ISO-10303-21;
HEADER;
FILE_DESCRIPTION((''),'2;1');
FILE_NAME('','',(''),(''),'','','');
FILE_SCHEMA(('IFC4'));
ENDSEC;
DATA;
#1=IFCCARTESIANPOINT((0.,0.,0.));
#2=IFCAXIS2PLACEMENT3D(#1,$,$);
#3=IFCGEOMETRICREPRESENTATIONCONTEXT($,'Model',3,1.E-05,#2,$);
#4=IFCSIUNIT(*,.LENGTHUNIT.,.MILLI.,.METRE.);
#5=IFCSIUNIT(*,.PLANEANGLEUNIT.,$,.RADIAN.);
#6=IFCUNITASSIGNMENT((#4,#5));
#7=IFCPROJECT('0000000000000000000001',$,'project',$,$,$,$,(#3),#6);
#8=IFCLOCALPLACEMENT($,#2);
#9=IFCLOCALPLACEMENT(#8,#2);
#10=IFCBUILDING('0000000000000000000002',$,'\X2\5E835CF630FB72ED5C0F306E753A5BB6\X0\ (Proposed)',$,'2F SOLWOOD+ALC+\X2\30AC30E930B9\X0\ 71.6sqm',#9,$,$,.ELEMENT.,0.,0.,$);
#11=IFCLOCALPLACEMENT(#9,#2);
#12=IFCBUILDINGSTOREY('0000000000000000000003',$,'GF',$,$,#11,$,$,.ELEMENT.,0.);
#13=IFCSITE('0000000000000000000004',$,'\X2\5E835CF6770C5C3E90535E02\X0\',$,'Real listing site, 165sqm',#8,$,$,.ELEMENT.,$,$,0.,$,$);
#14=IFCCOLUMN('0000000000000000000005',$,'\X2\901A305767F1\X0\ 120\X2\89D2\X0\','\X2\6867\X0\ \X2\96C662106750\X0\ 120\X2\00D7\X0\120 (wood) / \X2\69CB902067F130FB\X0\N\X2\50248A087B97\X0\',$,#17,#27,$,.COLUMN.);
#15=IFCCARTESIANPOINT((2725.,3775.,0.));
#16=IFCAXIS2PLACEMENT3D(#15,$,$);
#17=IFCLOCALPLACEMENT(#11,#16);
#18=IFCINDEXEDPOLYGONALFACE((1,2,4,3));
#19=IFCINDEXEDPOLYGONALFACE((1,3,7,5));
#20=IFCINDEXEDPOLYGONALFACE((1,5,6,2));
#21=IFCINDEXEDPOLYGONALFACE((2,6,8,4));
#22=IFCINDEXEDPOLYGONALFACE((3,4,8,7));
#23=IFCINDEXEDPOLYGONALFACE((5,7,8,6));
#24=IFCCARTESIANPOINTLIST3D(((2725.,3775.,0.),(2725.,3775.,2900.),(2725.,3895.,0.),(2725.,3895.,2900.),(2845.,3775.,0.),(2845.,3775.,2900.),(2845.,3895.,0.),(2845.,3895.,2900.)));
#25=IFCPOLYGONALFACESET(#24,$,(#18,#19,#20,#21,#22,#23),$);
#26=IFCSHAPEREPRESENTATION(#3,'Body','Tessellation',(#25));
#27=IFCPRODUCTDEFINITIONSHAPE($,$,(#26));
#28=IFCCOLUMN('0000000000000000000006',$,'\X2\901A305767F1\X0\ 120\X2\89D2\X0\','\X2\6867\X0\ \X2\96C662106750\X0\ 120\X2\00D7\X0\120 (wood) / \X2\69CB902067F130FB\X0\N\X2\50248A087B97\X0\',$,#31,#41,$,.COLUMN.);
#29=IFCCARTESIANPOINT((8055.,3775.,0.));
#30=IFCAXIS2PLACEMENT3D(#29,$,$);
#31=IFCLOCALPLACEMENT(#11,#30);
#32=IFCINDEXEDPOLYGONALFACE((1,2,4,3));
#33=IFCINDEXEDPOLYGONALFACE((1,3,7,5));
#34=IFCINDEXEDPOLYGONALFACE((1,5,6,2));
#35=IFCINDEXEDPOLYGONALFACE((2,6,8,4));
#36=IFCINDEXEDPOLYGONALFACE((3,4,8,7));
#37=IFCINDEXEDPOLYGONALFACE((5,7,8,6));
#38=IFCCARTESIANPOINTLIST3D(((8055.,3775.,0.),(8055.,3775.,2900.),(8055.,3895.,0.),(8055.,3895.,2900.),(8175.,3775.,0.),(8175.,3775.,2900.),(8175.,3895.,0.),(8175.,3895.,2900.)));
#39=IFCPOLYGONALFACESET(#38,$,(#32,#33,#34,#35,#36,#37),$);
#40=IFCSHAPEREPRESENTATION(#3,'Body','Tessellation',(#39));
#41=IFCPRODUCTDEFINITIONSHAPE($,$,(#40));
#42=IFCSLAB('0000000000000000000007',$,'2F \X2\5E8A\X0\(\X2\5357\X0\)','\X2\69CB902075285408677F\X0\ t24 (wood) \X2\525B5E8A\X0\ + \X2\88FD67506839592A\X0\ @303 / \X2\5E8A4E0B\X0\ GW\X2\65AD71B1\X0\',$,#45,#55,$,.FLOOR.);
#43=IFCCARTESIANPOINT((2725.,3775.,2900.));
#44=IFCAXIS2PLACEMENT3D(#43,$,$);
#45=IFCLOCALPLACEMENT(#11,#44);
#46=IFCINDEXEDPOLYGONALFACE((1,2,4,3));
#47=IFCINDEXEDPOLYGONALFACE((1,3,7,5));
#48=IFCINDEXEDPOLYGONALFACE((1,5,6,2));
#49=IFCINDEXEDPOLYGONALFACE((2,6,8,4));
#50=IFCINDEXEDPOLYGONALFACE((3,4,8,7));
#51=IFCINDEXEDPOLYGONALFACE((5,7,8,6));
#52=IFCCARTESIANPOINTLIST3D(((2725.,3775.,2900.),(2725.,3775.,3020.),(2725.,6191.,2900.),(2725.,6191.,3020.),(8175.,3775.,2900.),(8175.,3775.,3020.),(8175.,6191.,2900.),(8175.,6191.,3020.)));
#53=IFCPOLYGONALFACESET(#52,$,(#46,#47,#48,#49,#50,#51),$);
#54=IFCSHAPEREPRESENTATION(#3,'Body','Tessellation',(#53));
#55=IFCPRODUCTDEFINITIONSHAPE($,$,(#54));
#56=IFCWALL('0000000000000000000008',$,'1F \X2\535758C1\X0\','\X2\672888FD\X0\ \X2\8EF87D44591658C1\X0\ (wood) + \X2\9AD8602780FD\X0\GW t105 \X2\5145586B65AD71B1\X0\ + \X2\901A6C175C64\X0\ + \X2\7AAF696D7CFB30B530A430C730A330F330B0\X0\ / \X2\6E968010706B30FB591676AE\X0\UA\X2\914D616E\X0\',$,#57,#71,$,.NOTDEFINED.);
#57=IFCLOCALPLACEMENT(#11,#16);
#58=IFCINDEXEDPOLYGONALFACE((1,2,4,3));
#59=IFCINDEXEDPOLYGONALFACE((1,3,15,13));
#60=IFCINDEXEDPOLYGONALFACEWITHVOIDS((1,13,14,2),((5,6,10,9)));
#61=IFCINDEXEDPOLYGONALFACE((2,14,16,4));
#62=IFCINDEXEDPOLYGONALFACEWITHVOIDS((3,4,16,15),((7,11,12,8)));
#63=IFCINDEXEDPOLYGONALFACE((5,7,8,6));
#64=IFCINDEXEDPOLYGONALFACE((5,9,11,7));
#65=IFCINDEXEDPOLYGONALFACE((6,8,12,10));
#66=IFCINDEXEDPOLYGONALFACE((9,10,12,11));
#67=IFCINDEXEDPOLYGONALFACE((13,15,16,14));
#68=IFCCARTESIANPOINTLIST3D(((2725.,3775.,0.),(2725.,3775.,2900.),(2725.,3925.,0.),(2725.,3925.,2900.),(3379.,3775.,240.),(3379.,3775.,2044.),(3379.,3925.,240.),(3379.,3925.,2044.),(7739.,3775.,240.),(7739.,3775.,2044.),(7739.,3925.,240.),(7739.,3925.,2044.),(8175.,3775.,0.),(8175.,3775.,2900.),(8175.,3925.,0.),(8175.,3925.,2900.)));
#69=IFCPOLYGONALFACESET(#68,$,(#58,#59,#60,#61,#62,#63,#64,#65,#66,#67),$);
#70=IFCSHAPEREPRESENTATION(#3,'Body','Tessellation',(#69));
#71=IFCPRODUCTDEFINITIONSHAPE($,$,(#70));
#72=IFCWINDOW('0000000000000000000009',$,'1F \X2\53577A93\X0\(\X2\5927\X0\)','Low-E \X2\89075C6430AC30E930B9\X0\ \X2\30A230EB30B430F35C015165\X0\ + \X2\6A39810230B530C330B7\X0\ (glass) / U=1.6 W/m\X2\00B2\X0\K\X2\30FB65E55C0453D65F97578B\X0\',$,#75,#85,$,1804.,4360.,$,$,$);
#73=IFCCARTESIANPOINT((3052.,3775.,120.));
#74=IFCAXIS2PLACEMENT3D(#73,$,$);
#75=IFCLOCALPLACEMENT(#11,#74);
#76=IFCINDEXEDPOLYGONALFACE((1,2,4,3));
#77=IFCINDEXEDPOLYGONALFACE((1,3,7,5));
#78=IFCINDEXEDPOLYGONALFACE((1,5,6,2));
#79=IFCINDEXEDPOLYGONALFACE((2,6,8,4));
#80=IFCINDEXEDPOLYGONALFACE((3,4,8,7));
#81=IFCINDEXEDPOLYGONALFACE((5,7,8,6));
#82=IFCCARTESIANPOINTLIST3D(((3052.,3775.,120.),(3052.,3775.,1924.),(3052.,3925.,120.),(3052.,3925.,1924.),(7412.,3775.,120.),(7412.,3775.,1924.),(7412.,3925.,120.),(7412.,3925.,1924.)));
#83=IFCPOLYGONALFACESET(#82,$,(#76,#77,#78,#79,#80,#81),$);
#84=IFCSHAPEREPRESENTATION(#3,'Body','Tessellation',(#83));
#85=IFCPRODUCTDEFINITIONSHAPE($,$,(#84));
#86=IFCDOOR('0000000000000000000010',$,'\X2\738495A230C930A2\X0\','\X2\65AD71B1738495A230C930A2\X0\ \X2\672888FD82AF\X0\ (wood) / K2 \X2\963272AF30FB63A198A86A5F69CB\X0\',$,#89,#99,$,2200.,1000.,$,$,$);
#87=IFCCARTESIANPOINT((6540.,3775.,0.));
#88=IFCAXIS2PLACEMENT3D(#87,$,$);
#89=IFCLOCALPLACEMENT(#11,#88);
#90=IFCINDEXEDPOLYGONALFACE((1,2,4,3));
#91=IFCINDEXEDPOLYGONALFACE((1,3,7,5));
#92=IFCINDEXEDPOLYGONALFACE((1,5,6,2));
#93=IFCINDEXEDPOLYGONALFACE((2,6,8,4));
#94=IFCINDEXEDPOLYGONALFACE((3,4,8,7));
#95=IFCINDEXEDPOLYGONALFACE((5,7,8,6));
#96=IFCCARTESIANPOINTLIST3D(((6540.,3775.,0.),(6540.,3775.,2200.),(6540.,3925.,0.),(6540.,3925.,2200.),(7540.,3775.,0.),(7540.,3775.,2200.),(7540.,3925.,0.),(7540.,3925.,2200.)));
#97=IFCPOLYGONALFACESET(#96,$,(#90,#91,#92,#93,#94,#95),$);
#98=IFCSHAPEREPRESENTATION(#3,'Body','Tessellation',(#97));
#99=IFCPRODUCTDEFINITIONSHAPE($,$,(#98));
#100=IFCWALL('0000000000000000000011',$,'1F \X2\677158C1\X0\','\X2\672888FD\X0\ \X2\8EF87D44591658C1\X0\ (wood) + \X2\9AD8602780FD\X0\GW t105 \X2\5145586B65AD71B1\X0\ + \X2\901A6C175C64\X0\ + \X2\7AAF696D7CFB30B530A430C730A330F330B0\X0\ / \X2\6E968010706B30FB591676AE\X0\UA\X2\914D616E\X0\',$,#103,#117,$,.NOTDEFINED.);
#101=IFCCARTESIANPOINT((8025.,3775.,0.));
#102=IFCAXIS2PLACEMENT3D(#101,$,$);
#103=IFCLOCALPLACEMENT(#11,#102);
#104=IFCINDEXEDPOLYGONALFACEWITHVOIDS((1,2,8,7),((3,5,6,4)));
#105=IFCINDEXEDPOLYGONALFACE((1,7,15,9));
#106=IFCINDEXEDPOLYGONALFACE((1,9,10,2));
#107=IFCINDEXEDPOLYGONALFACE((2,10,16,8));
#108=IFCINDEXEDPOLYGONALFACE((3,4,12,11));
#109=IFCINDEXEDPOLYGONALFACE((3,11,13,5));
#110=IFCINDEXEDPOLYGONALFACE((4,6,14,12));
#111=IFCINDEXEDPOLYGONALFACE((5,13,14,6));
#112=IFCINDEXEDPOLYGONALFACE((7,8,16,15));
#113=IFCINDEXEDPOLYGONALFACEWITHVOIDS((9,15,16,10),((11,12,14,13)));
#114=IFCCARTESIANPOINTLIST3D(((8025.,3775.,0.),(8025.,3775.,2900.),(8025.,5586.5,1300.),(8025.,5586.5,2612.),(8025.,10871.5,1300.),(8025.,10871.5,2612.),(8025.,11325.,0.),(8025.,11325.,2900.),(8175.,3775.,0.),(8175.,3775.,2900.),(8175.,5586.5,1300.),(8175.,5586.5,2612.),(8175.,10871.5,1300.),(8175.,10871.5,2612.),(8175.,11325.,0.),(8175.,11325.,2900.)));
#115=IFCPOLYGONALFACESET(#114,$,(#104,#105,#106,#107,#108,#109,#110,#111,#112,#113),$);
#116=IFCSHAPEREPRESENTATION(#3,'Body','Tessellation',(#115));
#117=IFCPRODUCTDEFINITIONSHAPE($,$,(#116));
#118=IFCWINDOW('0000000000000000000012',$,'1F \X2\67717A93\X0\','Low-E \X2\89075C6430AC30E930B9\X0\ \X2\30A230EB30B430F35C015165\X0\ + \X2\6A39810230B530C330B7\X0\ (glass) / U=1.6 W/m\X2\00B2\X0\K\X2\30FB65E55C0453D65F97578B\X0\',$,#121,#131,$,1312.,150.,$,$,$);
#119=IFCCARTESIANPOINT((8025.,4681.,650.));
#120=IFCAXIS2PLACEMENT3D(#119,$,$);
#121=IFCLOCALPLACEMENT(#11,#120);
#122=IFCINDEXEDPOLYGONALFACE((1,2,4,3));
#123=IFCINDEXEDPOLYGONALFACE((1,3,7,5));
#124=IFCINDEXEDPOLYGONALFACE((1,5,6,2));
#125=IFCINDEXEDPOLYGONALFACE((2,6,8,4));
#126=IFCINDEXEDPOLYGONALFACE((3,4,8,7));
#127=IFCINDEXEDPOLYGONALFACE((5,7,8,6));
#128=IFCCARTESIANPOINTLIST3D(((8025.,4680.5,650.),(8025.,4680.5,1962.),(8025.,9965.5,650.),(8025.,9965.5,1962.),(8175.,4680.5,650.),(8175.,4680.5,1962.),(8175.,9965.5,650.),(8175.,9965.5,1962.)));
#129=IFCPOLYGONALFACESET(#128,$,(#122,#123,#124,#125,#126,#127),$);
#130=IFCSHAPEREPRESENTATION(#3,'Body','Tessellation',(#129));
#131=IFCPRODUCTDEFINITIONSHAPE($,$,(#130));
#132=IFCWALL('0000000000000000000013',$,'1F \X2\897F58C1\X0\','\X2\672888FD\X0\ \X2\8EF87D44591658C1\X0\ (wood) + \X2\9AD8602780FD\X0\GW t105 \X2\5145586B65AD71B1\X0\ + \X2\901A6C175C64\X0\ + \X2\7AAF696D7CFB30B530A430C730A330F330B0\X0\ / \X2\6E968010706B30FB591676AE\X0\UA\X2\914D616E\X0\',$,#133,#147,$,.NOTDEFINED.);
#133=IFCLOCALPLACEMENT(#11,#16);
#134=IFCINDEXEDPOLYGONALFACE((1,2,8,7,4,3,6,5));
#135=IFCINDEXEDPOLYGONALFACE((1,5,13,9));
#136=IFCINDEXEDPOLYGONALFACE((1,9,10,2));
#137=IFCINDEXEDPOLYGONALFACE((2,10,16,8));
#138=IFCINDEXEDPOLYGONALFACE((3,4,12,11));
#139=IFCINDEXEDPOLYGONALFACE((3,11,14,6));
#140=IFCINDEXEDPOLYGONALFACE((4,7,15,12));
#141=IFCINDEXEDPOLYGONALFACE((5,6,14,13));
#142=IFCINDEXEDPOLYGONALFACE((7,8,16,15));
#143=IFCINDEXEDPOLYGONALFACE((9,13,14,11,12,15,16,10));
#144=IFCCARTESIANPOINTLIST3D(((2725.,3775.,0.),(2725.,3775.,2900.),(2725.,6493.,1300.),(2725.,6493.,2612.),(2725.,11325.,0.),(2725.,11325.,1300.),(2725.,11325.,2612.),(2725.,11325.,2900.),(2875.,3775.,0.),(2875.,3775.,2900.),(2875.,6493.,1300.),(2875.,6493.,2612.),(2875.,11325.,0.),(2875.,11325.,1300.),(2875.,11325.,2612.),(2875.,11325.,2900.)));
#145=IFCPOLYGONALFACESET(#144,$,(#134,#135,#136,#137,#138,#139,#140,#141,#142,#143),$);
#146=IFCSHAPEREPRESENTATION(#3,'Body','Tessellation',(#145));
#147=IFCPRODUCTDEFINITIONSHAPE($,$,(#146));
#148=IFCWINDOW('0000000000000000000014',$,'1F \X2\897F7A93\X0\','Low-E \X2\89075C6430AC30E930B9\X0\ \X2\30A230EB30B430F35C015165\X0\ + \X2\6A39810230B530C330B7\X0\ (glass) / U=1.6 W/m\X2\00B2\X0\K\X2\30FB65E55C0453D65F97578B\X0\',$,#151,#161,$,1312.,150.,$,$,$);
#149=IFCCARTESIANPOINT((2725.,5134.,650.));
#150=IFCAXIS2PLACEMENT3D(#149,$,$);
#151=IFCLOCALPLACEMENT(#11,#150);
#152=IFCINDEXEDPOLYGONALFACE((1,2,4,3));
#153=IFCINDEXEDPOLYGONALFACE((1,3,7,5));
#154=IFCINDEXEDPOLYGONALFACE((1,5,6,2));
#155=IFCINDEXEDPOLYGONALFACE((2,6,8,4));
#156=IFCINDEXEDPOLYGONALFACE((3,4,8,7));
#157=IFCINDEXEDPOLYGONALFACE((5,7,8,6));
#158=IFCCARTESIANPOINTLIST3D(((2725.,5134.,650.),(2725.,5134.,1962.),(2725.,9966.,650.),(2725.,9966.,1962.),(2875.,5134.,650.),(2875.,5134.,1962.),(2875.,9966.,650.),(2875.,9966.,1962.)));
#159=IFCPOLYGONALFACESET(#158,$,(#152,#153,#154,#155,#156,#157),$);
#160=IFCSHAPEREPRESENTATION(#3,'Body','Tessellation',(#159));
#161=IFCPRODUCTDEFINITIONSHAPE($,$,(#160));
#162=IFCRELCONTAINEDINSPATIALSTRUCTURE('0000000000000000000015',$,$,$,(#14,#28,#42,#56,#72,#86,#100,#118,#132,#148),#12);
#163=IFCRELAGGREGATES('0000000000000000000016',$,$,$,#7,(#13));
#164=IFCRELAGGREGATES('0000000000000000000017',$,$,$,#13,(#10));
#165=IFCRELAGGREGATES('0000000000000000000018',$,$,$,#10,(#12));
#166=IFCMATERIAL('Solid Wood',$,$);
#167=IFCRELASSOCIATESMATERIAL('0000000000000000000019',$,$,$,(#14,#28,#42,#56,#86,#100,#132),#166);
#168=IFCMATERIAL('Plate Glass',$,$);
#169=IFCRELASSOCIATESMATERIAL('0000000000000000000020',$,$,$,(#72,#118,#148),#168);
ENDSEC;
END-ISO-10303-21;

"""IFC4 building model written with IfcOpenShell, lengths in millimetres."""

from ifc_helpers import new_model, si_unit, frame, frame_2d, origin, place, context, project, spatial, rectangle, extrude, material, element, fill, save


model = new_model("IFC4")

# Units and contexts
model_context = context("Model", 3, precision=1e-05, world=origin())
ifc_project = project(units=[si_unit("LENGTHUNIT", "METRE", prefix="MILLI"), si_unit("PLANEANGLEUNIT", "RADIAN")], contexts=[model_context])

# Site, building, storey
site_placement = place(None, origin())
site = spatial("IfcSite", under=ifc_project, at=site_placement, Name="広島県尾道市", ObjectType="Real listing site, 165sqm", CompositionType="ELEMENT", RefElevation=0.0)
building_placement = place(site_placement, origin())
building = spatial("IfcBuilding", under=site, at=building_placement, Name="広島・狭小の町家 (Proposed)", ObjectType="2F SOLWOOD+ALC+ガラス 71.6sqm", CompositionType="ELEMENT", ElevationOfRefHeight=0.0, ElevationOfTerrain=0.0)
storey_placement = place(building_placement, origin())
storey = spatial("IfcBuildingStorey", under=building, at=storey_placement, Name="GF", CompositionType="ELEMENT", Elevation=0.0)

# Columns
ifc_material_1 = material(Name="Solid Wood")
column_1_placement = place(storey_placement, frame((2725.0, 3775.0, 0.0)))
element("IfcColumn", 1, at=column_1_placement, inside=storey, material=ifc_material_1, Name="通し柱 120角", Description="桧 集成材 120×120 (wood) / 構造柱・N値計算", PredefinedType="COLUMN", context=model_context, shape_type="SweptSolid", body=[
    extrude(rectangle(XDim=120.0, YDim=120.0, at=frame_2d((60.0, 60.0))), frame((2725.0, 3775.0, 0.0)), (0.0, 0.0, 1.0), 2900.0),
])
column_2_placement = place(storey_placement, frame((8055.0, 3775.0, 0.0)))
element("IfcColumn", 2, at=column_2_placement, inside=storey, material=ifc_material_1, Name="通し柱 120角", Description="桧 集成材 120×120 (wood) / 構造柱・N値計算", PredefinedType="COLUMN", context=model_context, shape_type="SweptSolid", body=[
    extrude(rectangle(XDim=120.0, YDim=120.0, at=frame_2d((60.0, 60.0))), frame((8055.0, 3775.0, 0.0)), (0.0, 0.0, 1.0), 2900.0),
])

# Slab
slab_1_placement = place(storey_placement, frame((2725.0, 3775.0, 2900.0)))
element("IfcSlab", 3, at=slab_1_placement, inside=storey, material=ifc_material_1, Name="2F 床(南)", Description="構造用合板 t24 (wood) 剛床 + 製材根太 @303 / 床下 GW断熱", PredefinedType="FLOOR", context=model_context, shape_type="SweptSolid", body=[
    extrude(rectangle(XDim=5450.0, YDim=2416.0, at=frame_2d((2725.0, 1208.0))), frame((2725.0, 3775.0, 2900.0)), (0.0, 0.0, 1.0), 120.0),
])

# Wall, openings, window, door
wall_1_placement = place(storey_placement, frame((2725.0, 3775.0, 0.0)))
wall_1 = element("IfcWall", 4, at=wall_1_placement, inside=storey, material=ifc_material_1, Name="1F 南壁", Description="木製 軸組外壁 (wood) + 高性能GW t105 充填断熱 + 通気層 + 窯業系サイディング / 準耐火・外皮UA配慮", PredefinedType="NOTDEFINED", context=model_context, shape_type="SweptSolid", body=[
    extrude(rectangle(XDim=5450.0, YDim=150.0, at=frame_2d((2725.0, 75.0))), frame((2725.0, 3775.0, 0.0)), (0.0, 0.0, 1.0), 2900.0),
])
opening_1_placement = place(storey_placement, frame((3052.0, 3775.0, 120.0)))
opening_1 = element("IfcOpeningElement", 5, at=opening_1_placement, cuts=wall_1, PredefinedType="NOTDEFINED", context=model_context, shape_type="SweptSolid", body=[
    extrude(rectangle(XDim=4360.0, YDim=150.0, at=frame_2d((2180.0, 75.0))), frame((3052.0, 3775.0, 120.0)), (0.0, 0.0, 1.0), 1804.0),
])
opening_2_placement = place(storey_placement, frame((6540.0, 3775.0, 0.0)))
opening_2 = element("IfcOpeningElement", 6, at=opening_2_placement, cuts=wall_1, PredefinedType="NOTDEFINED", context=model_context, shape_type="SweptSolid", body=[
    extrude(rectangle(XDim=1000.0, YDim=150.0, at=frame_2d((500.0, 75.0))), frame((6540.0, 3775.0, 0.0)), (0.0, 0.0, 1.0), 2200.0),
])
ifc_material_2 = material(Name="Plate Glass")
window_1_placement = place(storey_placement, frame((3052.0, 3775.0, 120.0)))
window_1 = element("IfcWindow", 7, at=window_1_placement, inside=storey, material=ifc_material_2, Name="1F 南窓(大)", Description="Low-E 複層ガラス アルゴン封入 + 樹脂サッシ (glass) / U=1.6 W/m²K・日射取得型", OverallHeight=1804.0, OverallWidth=4360.0, context=model_context, shape_type="SweptSolid", body=[
    extrude(rectangle(XDim=4360.0, YDim=150.0, at=frame_2d((2180.0, 75.0))), frame((3052.0, 3775.0, 120.0)), (0.0, 0.0, 1.0), 1804.0),
])
fill(opening_1, window_1)
door_placement = place(storey_placement, frame((6540.0, 3775.0, 0.0)))
door = element("IfcDoor", 8, at=door_placement, inside=storey, material=ifc_material_1, Name="玄関ドア", Description="断熱玄関ドア 木製芯 (wood) / K2 防犯・採風機構", OverallHeight=2200.0, OverallWidth=1000.0, context=model_context, shape_type="SweptSolid", body=[
    extrude(rectangle(XDim=1000.0, YDim=150.0, at=frame_2d((500.0, 75.0))), frame((6540.0, 3775.0, 0.0)), (0.0, 0.0, 1.0), 2200.0),
])
fill(opening_2, door)

# Walls, openings, windows
wall_2_placement = place(storey_placement, frame((8025.0, 3775.0, 0.0)))
wall_2 = element("IfcWall", 9, at=wall_2_placement, inside=storey, material=ifc_material_1, Name="1F 東壁", Description="木製 軸組外壁 (wood) + 高性能GW t105 充填断熱 + 通気層 + 窯業系サイディング / 準耐火・外皮UA配慮", PredefinedType="NOTDEFINED", context=model_context, shape_type="SweptSolid", body=[
    extrude(rectangle(XDim=150.0, YDim=7550.0, at=frame_2d((75.0, 3775.0))), frame((8025.0, 3775.0, 0.0)), (0.0, 0.0, 1.0), 2900.0),
])
opening_3_placement = place(storey_placement, frame((8025.0, 4681.0, 650.0)))
opening_3 = element("IfcOpeningElement", 10, at=opening_3_placement, cuts=wall_2, PredefinedType="NOTDEFINED", context=model_context, shape_type="SweptSolid", body=[
    extrude(rectangle(XDim=150.0, YDim=5285.0, at=frame_2d((75.0, 2642.0))), frame((8025.0, 4681.0, 650.0)), (0.0, 0.0, 1.0), 1312.0),
])
window_2_placement = place(storey_placement, frame((8025.0, 4681.0, 650.0)))
window_2 = element("IfcWindow", 11, at=window_2_placement, inside=storey, material=ifc_material_2, Name="1F 東窓", Description="Low-E 複層ガラス アルゴン封入 + 樹脂サッシ (glass) / U=1.6 W/m²K・日射取得型", OverallHeight=1312.0, OverallWidth=150.0, context=model_context, shape_type="SweptSolid", body=[
    extrude(rectangle(XDim=150.0, YDim=5285.0, at=frame_2d((75.0, 2642.0))), frame((8025.0, 4681.0, 650.0)), (0.0, 0.0, 1.0), 1312.0),
])
fill(opening_3, window_2)
wall_3_placement = place(storey_placement, frame((2725.0, 3775.0, 0.0)))
wall_3 = element("IfcWall", 12, at=wall_3_placement, inside=storey, material=ifc_material_1, Name="1F 西壁", Description="木製 軸組外壁 (wood) + 高性能GW t105 充填断熱 + 通気層 + 窯業系サイディング / 準耐火・外皮UA配慮", PredefinedType="NOTDEFINED", context=model_context, shape_type="SweptSolid", body=[
    extrude(rectangle(XDim=150.0, YDim=7550.0, at=frame_2d((75.0, 3775.0))), frame((2725.0, 3775.0, 0.0)), (0.0, 0.0, 1.0), 2900.0),
])
opening_4_placement = place(storey_placement, frame((2725.0, 5134.0, 650.0)))
opening_4 = element("IfcOpeningElement", 13, at=opening_4_placement, cuts=wall_3, PredefinedType="NOTDEFINED", context=model_context, shape_type="SweptSolid", body=[
    extrude(rectangle(XDim=150.0, YDim=4832.0, at=frame_2d((75.0, 2416.0))), frame((2725.0, 5134.0, 650.0)), (0.0, 0.0, 1.0), 1312.0),
])
window_3_placement = place(storey_placement, frame((2725.0, 5134.0, 650.0)))
window_3 = element("IfcWindow", 14, at=window_3_placement, inside=storey, material=ifc_material_2, Name="1F 西窓", Description="Low-E 複層ガラス アルゴン封入 + 樹脂サッシ (glass) / U=1.6 W/m²K・日射取得型", OverallHeight=1312.0, OverallWidth=150.0, context=model_context, shape_type="SweptSolid", body=[
    extrude(rectangle(XDim=150.0, YDim=4832.0, at=frame_2d((75.0, 2416.0))), frame((2725.0, 5134.0, 650.0)), (0.0, 0.0, 1.0), 1312.0),
])
fill(opening_4, window_3)

save(model, "model.ifc")
